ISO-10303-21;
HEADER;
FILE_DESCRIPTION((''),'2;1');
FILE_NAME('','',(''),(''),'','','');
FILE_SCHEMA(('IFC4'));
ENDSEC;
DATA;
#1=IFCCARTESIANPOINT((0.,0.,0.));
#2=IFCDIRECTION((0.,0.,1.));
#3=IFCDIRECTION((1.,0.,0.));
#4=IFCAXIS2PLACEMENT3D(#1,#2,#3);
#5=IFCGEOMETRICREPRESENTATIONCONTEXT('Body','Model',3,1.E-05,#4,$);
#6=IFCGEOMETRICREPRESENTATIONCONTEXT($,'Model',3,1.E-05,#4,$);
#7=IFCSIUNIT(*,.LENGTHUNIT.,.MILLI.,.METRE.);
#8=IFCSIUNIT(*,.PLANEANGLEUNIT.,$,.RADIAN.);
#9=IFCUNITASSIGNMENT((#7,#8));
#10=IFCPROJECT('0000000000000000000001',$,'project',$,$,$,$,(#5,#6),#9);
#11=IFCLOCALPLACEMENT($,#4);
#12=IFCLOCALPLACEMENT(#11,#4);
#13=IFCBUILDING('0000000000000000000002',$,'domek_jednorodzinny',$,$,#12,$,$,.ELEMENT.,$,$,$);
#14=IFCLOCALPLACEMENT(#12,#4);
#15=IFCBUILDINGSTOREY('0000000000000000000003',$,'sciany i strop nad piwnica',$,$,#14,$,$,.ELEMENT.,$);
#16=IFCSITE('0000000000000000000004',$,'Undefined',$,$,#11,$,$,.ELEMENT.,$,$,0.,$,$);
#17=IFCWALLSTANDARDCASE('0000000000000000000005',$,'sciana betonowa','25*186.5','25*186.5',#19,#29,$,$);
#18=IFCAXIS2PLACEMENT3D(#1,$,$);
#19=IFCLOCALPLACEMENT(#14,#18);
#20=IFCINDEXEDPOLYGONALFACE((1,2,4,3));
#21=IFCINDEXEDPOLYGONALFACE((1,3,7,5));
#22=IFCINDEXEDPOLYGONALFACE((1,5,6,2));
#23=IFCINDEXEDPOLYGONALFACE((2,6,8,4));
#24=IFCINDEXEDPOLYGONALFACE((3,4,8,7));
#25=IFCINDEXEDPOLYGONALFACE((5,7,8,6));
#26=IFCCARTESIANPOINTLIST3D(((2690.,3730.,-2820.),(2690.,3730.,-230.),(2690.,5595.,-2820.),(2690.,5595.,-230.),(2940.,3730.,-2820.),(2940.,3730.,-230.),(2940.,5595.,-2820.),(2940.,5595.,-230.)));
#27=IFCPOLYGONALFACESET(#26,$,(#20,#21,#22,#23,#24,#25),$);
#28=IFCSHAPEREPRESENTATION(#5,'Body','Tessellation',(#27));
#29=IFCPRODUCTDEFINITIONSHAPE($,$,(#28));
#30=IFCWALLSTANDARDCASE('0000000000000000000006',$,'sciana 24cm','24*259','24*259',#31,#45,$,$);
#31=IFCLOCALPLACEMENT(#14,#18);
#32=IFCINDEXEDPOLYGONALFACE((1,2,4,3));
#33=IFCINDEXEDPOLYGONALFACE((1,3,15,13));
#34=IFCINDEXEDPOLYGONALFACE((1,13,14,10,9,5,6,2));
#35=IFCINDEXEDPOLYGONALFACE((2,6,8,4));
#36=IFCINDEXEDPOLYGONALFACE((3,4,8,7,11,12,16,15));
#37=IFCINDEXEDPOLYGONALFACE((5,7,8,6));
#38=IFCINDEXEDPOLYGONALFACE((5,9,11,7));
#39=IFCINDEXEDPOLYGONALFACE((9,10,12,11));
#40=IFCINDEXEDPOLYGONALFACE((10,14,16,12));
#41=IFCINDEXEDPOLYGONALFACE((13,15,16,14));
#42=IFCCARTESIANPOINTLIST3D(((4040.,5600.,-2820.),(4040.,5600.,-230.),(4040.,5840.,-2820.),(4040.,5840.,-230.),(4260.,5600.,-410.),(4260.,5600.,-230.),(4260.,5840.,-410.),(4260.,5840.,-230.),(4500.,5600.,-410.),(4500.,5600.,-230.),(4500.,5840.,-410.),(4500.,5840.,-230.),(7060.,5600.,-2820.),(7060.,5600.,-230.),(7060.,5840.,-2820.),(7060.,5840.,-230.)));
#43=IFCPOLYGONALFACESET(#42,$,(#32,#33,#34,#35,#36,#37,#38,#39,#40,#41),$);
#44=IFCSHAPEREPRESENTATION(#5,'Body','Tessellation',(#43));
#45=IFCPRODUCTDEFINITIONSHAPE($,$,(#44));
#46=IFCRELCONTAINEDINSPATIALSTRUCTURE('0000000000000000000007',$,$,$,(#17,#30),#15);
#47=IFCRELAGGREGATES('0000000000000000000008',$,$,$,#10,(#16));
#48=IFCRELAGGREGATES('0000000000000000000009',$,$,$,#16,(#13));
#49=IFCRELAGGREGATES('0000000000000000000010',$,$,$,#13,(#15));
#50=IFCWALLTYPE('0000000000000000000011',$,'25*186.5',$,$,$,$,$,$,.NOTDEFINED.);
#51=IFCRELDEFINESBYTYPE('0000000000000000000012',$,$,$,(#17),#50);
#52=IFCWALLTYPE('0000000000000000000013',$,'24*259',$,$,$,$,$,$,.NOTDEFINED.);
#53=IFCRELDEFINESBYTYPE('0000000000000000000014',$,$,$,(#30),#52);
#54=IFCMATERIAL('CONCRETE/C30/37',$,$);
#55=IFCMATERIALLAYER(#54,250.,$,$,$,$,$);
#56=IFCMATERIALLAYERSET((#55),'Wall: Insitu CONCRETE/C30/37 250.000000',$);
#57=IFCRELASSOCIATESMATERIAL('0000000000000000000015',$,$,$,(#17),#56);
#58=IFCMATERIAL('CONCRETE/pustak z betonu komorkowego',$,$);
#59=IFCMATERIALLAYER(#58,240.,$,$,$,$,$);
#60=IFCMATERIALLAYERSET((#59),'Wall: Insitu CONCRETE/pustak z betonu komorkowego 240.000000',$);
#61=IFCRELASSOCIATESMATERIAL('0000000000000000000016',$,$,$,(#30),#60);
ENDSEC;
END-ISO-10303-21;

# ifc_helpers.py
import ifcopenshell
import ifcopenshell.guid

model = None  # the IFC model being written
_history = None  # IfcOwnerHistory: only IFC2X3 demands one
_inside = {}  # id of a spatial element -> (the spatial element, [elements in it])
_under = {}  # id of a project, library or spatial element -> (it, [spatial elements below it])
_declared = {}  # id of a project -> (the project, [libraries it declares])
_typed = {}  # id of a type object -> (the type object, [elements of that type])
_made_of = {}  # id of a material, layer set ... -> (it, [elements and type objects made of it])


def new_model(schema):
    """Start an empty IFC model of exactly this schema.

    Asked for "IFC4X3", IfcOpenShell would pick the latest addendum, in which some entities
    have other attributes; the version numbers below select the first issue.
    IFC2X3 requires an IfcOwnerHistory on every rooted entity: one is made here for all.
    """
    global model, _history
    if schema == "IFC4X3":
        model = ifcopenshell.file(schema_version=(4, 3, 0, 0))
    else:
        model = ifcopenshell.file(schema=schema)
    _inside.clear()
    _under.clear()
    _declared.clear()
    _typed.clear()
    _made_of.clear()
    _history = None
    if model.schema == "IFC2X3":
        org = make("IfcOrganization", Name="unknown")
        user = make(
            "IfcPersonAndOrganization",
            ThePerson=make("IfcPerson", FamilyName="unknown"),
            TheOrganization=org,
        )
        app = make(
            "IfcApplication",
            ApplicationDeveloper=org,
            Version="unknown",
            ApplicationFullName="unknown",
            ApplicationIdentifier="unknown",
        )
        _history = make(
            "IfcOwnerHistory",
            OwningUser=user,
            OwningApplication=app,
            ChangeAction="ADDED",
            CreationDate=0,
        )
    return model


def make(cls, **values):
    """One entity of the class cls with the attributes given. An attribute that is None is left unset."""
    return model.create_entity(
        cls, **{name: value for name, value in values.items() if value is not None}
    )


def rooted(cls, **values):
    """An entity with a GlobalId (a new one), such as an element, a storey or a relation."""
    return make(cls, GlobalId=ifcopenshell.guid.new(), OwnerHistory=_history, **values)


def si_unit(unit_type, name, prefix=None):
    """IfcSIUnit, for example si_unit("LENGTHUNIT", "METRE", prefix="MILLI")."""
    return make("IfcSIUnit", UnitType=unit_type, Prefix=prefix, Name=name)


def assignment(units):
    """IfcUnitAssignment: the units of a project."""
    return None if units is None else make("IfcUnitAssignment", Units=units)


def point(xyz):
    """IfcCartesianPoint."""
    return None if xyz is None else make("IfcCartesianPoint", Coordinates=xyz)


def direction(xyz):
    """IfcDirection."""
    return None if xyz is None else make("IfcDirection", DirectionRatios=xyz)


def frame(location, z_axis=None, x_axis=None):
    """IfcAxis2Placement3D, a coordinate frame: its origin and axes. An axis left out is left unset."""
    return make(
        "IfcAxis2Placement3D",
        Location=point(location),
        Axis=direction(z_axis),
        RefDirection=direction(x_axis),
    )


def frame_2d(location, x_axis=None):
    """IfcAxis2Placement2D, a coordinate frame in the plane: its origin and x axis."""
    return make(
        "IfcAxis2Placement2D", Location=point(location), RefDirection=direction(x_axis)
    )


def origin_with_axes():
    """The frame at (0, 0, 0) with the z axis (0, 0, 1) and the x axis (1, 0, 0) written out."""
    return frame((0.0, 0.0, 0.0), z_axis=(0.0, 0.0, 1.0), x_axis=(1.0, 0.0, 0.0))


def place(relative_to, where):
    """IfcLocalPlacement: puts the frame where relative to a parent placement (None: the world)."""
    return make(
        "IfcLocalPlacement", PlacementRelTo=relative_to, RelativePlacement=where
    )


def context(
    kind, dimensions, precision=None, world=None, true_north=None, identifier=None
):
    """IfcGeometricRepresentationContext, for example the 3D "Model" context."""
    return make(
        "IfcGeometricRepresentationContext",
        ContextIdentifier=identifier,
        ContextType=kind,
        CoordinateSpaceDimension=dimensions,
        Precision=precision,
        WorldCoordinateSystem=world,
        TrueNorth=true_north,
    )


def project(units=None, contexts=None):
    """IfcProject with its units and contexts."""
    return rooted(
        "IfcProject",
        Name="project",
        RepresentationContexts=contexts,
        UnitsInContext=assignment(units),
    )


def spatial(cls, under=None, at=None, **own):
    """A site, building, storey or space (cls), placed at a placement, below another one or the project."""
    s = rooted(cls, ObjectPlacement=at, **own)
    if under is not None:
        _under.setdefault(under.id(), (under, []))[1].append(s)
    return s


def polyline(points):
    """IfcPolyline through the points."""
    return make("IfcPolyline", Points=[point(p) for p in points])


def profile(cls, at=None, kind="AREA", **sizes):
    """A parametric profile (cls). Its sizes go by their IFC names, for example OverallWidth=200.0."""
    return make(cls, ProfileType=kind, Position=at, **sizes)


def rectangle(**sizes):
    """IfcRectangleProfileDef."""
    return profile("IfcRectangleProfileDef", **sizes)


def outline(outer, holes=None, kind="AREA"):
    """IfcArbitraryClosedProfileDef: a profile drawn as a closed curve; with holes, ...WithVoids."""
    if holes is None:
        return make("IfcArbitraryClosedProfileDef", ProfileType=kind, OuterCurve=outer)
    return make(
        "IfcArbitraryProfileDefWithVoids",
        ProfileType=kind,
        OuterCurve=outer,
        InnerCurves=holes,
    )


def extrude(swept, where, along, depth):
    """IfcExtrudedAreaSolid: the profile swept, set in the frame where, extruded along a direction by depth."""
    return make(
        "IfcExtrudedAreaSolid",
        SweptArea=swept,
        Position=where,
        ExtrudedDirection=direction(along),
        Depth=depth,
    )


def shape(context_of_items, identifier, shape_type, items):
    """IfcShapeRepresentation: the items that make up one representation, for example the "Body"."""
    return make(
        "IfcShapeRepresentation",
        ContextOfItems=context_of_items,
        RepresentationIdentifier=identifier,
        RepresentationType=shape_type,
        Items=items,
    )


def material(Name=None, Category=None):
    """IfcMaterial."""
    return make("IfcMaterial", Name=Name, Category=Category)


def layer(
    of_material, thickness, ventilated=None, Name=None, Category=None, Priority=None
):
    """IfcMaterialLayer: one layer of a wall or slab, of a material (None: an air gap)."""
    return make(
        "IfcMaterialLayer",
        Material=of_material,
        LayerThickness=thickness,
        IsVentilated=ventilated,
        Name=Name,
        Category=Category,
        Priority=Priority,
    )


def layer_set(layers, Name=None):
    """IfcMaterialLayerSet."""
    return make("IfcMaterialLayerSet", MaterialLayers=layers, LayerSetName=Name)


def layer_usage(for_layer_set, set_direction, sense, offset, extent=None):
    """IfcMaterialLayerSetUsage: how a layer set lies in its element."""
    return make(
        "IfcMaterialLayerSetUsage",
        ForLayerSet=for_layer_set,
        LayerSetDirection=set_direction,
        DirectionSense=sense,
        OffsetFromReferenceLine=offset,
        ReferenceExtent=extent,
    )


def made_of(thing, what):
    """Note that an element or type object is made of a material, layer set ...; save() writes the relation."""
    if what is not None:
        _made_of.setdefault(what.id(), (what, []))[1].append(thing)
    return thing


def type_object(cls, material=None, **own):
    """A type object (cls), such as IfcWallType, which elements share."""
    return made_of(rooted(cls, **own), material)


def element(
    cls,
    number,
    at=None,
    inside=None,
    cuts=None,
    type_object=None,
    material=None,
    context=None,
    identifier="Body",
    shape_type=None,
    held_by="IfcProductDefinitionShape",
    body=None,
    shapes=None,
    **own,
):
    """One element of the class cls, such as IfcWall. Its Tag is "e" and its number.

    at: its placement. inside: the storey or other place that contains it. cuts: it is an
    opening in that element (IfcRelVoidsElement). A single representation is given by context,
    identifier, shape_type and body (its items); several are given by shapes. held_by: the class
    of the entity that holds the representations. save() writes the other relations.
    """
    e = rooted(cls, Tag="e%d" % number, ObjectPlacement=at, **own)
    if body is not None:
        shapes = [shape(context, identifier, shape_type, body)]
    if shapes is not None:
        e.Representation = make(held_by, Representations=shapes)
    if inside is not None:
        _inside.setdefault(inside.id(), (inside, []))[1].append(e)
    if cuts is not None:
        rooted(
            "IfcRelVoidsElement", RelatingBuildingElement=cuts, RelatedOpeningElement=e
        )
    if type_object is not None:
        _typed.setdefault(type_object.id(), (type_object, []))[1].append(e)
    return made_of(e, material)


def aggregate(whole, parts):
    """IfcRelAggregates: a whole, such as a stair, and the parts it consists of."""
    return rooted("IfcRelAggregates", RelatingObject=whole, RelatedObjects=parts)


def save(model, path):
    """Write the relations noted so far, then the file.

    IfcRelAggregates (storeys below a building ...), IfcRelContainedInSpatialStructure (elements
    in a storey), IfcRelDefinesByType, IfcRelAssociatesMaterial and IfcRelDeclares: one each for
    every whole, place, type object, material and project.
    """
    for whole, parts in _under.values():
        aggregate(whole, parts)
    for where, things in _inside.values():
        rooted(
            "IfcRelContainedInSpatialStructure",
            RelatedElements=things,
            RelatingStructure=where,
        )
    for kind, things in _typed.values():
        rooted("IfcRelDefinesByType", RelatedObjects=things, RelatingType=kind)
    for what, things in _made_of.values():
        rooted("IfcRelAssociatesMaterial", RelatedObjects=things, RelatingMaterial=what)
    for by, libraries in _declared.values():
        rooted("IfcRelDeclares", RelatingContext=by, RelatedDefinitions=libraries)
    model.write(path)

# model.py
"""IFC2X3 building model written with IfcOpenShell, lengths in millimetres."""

from ifc_helpers import new_model, si_unit, frame, frame_2d, origin_with_axes, place, context, project, spatial, polyline, rectangle, outline, extrude, material, layer, layer_set, layer_usage, type_object, element, save


model = new_model("IFC2X3")

# Units and contexts
model_context_1 = context("Model", 3, precision=1e-05, world=origin_with_axes(), identifier="Body")
model_context_2 = context("Model", 3, precision=1e-05, world=origin_with_axes())
ifc_project = project(units=[si_unit("LENGTHUNIT", "METRE", prefix="MILLI"), si_unit("PLANEANGLEUNIT", "RADIAN")], contexts=[model_context_1, model_context_2])

# Site, building, storey
site_placement = place(None, origin_with_axes())
site = spatial("IfcSite", under=ifc_project, at=site_placement, Name="Undefined", CompositionType="ELEMENT", RefElevation=0.0)
building_placement = place(site_placement, origin_with_axes())
building = spatial("IfcBuilding", under=site, at=building_placement, Name="domek_jednorodzinny", CompositionType="ELEMENT")
storey_placement = place(building_placement, origin_with_axes())
storey = spatial("IfcBuildingStorey", under=building, at=storey_placement, Name="sciany i strop nad piwnica", CompositionType="ELEMENT")

# Shared definitions
ifc_material_1 = material(Name="CONCRETE/C30/37")

# Wall
ifc_material_2 = material(Name="CONCRETE/pustak z betonu komorkowego")
ifc_layer_1 = layer(ifc_material_2, 240.0)
ifc_layer_set_1 = layer_set([ifc_layer_1], Name="Wall: Insitu CONCRETE/pustak z betonu komorkowego 240.000000")
ifc_layer_2 = layer(ifc_material_1, 250.0)
ifc_layer_set_2 = layer_set([ifc_layer_2], Name="Wall: Insitu CONCRETE/C30/37 250.000000")
ifc_layer_usage_1 = layer_usage(ifc_layer_set_2, "AXIS2", "POSITIVE", -125.0)
wall_type_1 = type_object("IfcWallType", Name="25*186.5", PredefinedType="NOTDEFINED")
wall_1_placement = place(storey_placement, frame((2815.0, 3730.0, -2820.0), z_axis=(0.0, 0.0, 1.0), x_axis=(0.0, 1.0, 0.0)))
element("IfcWallStandardCase", 1, at=wall_1_placement, inside=storey, type_object=wall_type_1, material=ifc_layer_usage_1, Name="sciana betonowa", Description="25*186.5", ObjectType="25*186.5", context=model_context_1, shape_type="SweptSolid", body=[
    extrude(rectangle(XDim=1865.0, YDim=250.0, at=frame_2d((0.0, 932.5), x_axis=(0.0, -1.0))), frame((0.0, 0.0, 0.0), z_axis=(0.0, 0.0, 1.0), x_axis=(0.0, -1.0, 0.0)), (0.0, 0.0, 1.0), 2590.0),
])

# Wall, opening
ifc_layer_usage_2 = layer_usage(ifc_layer_set_1, "AXIS2", "POSITIVE", -120.0)
wall_type_2 = type_object("IfcWallType", Name="24*259", PredefinedType="NOTDEFINED")
wall_2_placement = place(storey_placement, frame((4040.0, 5720.0, -2820.0), z_axis=(0.0, 0.0, 1.0), x_axis=(1.0, 0.0, 0.0)))
wall_2 = element("IfcWallStandardCase", 2, at=wall_2_placement, inside=storey, type_object=wall_type_2, material=ifc_layer_usage_2, Name="sciana 24cm", Description="24*259", ObjectType="24*259", context=model_context_1, shape_type="SweptSolid", body=[
    extrude(rectangle(XDim=3020.0, YDim=240.0, at=frame_2d((0.0, 1510.0), x_axis=(0.0, -1.0))), frame((0.0, 0.0, 0.0), z_axis=(0.0, 0.0, 1.0), x_axis=(0.0, -1.0, 0.0)), (0.0, 0.0, 1.0), 2590.0),
])
opening_1_placement = place(storey_placement, frame((4040.0, 5720.0, -2820.0), z_axis=(0.0, 0.0, 1.0), x_axis=(1.0, 0.0, 0.0)))
element("IfcOpeningElement", 3, at=opening_1_placement, cuts=wall_2, ObjectType="Recess", context=model_context_1, shape_type="SweptSolid", body=[
    extrude(outline(polyline([(0.0, 0.0), (180.0, 0.0), (180.0, 240.0), (0.0, 240.0), (0.0, 0.0)])), frame((220.0, -123.0, 2410.0), z_axis=(0.0, 1.0, 0.0), x_axis=(0.0, 0.0, 1.0)), (0.0, 0.0, 1.0), 246.0),
])

save(model, "model.ifc")
